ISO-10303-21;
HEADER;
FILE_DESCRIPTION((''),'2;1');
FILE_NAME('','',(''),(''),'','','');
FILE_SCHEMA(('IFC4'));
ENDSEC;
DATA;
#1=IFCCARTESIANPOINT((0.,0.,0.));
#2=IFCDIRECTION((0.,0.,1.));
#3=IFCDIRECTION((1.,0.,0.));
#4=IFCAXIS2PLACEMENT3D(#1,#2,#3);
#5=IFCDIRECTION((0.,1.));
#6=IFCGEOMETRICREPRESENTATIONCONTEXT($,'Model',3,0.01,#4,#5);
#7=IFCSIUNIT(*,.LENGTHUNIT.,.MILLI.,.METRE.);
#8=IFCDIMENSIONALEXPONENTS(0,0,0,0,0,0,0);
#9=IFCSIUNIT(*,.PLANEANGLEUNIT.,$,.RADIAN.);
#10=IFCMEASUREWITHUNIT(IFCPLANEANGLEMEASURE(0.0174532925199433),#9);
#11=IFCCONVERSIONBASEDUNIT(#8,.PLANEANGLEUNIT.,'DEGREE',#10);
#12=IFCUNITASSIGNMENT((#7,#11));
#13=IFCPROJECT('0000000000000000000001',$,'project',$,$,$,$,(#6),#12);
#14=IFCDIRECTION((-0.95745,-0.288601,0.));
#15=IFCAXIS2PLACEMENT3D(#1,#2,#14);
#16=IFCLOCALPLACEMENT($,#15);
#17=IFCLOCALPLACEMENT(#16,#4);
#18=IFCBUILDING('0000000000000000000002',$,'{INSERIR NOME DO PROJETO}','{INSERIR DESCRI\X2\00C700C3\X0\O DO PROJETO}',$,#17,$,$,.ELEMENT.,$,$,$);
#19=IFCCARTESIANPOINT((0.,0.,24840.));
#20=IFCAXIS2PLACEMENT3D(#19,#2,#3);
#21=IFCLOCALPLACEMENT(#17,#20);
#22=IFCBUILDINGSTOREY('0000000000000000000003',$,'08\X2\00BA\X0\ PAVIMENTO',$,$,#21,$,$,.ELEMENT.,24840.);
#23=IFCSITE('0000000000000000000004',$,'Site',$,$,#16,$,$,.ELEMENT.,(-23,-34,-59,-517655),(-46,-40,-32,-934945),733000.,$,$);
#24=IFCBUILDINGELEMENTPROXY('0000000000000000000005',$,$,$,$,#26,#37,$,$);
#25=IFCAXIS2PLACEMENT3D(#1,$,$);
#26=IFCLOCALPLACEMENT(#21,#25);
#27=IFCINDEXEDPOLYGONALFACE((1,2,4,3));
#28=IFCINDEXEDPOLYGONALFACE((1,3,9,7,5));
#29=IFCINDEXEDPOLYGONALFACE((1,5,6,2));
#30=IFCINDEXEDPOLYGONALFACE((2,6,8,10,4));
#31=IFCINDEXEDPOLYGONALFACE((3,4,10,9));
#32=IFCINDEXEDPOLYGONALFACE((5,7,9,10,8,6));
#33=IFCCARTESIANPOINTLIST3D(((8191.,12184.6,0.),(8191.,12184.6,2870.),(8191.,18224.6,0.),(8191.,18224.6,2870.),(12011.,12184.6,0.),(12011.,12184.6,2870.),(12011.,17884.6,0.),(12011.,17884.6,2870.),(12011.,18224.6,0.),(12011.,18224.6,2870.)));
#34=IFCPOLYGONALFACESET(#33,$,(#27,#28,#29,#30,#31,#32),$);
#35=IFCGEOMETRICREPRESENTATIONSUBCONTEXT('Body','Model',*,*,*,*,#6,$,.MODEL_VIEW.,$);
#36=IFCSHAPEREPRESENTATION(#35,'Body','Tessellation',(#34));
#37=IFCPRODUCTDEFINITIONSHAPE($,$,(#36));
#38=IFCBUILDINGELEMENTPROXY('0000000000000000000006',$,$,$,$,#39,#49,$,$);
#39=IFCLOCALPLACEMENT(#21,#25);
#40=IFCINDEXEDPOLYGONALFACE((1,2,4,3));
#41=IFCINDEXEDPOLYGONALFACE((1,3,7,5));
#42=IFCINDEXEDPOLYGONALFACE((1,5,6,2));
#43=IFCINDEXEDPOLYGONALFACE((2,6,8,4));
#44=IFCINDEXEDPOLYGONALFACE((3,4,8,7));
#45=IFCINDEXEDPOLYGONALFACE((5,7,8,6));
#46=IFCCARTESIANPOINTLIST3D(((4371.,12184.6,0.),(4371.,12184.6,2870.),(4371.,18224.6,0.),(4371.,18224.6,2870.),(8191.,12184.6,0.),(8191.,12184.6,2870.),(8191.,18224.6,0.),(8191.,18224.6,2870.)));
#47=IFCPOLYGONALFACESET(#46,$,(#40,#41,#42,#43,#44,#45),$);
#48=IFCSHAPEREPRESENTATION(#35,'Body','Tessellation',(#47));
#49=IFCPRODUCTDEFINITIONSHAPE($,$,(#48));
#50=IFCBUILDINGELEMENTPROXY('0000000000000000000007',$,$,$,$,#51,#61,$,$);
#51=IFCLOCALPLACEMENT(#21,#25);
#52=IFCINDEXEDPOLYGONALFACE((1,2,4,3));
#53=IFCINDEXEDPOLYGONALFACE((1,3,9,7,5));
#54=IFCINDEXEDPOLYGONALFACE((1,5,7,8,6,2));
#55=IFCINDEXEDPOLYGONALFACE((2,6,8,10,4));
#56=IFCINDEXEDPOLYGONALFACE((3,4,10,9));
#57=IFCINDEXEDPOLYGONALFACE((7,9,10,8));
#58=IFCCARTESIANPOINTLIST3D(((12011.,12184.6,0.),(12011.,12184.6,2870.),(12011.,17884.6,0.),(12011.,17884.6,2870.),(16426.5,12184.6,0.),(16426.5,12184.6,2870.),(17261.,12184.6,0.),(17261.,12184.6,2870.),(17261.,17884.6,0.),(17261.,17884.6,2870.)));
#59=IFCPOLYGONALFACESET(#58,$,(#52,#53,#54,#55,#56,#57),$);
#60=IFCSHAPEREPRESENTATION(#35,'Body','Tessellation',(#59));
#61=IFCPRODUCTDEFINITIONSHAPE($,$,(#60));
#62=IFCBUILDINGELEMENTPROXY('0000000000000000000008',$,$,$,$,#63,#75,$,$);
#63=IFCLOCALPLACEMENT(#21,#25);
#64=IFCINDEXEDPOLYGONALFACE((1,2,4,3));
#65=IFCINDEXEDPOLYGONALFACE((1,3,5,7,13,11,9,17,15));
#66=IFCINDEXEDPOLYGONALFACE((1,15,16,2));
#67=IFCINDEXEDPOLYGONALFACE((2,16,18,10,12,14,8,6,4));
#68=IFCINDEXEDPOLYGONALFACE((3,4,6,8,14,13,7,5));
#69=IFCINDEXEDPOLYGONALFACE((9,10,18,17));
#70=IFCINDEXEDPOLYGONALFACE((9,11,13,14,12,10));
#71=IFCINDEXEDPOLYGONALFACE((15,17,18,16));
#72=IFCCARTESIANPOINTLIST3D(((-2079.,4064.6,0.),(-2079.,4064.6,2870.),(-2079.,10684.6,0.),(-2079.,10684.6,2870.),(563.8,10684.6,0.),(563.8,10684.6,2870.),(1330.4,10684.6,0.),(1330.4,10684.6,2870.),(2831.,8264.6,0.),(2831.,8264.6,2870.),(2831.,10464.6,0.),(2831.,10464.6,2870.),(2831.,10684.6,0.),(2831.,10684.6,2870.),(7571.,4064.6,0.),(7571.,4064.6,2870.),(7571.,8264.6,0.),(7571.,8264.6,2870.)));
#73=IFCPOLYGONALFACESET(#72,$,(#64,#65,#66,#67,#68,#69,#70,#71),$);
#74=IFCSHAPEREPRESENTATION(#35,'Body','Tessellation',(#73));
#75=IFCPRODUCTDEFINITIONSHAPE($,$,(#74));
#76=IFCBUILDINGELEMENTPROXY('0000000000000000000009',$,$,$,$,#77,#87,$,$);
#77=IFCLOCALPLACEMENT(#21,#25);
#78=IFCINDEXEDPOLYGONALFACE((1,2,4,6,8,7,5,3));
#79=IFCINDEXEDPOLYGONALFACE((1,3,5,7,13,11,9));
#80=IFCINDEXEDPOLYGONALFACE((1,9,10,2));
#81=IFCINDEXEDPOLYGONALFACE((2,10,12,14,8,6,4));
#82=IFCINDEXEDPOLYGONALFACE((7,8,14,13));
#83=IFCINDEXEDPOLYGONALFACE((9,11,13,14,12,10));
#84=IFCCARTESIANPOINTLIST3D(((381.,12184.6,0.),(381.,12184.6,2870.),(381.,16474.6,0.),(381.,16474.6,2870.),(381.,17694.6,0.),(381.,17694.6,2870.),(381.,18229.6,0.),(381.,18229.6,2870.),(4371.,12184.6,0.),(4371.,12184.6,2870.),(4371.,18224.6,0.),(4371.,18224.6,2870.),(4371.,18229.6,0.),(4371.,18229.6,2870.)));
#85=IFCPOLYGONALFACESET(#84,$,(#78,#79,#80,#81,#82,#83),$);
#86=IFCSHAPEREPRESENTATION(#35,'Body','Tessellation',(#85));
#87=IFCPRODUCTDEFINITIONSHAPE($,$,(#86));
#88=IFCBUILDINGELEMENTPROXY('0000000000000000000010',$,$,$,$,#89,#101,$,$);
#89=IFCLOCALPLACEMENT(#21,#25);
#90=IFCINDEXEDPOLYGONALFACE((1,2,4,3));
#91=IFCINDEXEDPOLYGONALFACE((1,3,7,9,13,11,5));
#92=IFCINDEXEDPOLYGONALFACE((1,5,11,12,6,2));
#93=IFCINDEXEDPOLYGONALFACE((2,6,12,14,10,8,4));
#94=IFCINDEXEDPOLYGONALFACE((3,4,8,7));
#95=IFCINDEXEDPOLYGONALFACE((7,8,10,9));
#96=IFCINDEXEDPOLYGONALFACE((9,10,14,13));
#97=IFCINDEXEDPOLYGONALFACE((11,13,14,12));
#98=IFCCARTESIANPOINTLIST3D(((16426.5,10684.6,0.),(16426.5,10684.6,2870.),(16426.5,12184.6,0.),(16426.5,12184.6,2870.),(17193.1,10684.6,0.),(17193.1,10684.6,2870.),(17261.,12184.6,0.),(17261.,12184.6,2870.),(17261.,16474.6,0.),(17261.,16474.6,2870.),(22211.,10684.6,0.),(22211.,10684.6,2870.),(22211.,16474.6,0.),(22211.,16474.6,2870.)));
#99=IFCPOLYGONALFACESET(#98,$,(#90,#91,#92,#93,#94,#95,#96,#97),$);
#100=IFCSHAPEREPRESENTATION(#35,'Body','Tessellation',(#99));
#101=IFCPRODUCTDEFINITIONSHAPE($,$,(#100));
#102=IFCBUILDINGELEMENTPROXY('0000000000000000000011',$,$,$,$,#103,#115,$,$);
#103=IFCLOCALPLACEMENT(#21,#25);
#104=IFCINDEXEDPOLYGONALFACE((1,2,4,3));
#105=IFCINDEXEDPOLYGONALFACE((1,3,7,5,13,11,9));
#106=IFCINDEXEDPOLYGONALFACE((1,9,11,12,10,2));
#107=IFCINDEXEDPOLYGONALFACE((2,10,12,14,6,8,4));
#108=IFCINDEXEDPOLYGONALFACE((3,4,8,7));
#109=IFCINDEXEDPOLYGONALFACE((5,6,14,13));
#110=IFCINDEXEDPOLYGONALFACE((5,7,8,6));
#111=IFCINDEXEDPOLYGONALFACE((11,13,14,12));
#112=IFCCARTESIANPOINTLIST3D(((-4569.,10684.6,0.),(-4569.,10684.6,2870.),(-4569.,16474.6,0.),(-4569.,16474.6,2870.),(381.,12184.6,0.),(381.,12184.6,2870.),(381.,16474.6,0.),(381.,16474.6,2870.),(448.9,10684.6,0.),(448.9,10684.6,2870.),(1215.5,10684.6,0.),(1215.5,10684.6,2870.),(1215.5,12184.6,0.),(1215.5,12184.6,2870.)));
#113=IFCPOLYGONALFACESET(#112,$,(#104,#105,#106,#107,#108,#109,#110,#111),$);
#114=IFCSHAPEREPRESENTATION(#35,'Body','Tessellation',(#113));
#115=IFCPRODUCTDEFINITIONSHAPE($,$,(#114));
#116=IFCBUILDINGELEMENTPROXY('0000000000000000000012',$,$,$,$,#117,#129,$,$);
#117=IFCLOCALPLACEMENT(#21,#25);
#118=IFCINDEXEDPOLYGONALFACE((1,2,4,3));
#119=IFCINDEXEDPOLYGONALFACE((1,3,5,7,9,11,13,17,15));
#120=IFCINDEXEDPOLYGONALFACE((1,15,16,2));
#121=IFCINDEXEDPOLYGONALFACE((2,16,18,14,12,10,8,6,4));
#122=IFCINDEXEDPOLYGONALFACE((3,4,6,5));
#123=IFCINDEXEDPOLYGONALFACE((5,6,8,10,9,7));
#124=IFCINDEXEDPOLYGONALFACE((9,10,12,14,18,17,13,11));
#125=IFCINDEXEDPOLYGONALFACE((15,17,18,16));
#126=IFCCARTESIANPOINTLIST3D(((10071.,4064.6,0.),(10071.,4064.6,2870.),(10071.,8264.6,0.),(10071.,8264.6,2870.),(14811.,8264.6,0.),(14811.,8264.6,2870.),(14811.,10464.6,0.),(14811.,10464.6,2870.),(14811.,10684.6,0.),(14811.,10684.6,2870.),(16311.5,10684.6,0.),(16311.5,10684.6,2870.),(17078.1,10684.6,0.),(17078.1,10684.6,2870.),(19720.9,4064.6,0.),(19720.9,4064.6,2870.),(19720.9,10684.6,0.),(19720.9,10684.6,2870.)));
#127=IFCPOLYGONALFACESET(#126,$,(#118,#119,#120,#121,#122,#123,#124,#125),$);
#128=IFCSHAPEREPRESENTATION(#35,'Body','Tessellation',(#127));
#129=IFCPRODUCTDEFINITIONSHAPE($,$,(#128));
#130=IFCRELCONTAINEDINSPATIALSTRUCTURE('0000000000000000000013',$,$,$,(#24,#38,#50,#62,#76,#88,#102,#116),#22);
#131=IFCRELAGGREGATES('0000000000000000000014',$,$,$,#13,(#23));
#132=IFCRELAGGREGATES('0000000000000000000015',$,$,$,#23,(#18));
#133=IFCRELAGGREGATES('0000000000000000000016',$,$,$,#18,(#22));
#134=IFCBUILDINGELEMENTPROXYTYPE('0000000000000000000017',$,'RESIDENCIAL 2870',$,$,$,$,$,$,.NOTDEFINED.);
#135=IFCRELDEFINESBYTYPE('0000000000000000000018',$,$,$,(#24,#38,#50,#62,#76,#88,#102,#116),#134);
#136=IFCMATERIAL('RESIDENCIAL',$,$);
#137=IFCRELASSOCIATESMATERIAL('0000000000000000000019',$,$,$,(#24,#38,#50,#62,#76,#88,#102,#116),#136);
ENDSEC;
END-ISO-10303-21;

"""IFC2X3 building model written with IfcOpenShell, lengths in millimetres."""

from ifc_helpers import new_model, entity, si_unit, converted_unit, direction, frame, origin_with_axes, place, context, subcontext, project, spatial, polyline, outline, extrude, material, type_object, element, save


model = new_model("IFC2X3")

# Units and contexts
model_context = context("Model", 3, precision=0.01, world=origin_with_axes(), true_north=direction((0.0, 1.0)))
body_context = subcontext(model_context, "Body", "Model", "MODEL_VIEW")
ifc_project = project(units=[si_unit("LENGTHUNIT", "METRE", prefix="MILLI"), converted_unit("PLANEANGLEUNIT", "DEGREE", entity("IfcPlaneAngleMeasure", 0.0174532925199433), si_unit("PLANEANGLEUNIT", "RADIAN"), dimensions=[0, 0, 0, 0, 0, 0, 0])], contexts=[model_context])

# Site, building, storey
site_placement = place(None, frame((0.0, 0.0, 0.0), z_axis=(0.0, 0.0, 1.0), x_axis=(-0.95745, -0.288601, 0.0)))
site = spatial("IfcSite", under=ifc_project, at=site_placement, Name="Site", CompositionType="ELEMENT", RefLatitude=(-23, -34, -59, -517655), RefLongitude=(-46, -40, -32, -934945), RefElevation=733000.0)
building_placement = place(site_placement, origin_with_axes())
building = spatial("IfcBuilding", under=site, at=building_placement, Name="{INSERIR NOME DO PROJETO}", Description="{INSERIR DESCRIÇÃO DO PROJETO}", CompositionType="ELEMENT")
storey_placement = place(building_placement, frame((0.0, 0.0, 24840.0), z_axis=(0.0, 0.0, 1.0), x_axis=(1.0, 0.0, 0.0)))
storey = spatial("IfcBuildingStorey", under=building, at=storey_placement, Name="08º PAVIMENTO", CompositionType="ELEMENT", Elevation=24840.0)

# Building element proxies
ifc_material_1 = material(Name="RESIDENCIAL")
building_element_proxy_type_1 = type_object("IfcBuildingElementProxyType", Name="RESIDENCIAL 2870", PredefinedType="NOTDEFINED")
proxy_1_placement = place(storey_placement, frame((8191.0, 18224.6, 0.0), z_axis=(0.0, 0.0, 1.0), x_axis=(1.0, 0.0, 0.0)))
element("IfcBuildingElementProxy", 1, at=proxy_1_placement, inside=storey, type_object=building_element_proxy_type_1, material=ifc_material_1, context=body_context, shape_type="SweptSolid", body=[
    extrude(outline(polyline([(0.0, 0.0), (0.0, -6040.0), (3820.0, -6040.0), (3820.0, -340.0), (3820.0, 0.0), (0.0, 0.0)])), origin_with_axes(), (0.0, 0.0, 1.0), 2870.0),
])
proxy_2_placement = place(storey_placement, frame((4371.0, 18224.6, 0.0), z_axis=(0.0, 0.0, 1.0), x_axis=(1.0, 0.0, 0.0)))
element("IfcBuildingElementProxy", 2, at=proxy_2_placement, inside=storey, type_object=building_element_proxy_type_1, material=ifc_material_1, context=body_context, shape_type="SweptSolid", body=[
    extrude(outline(polyline([(0.0, 0.0), (0.0, -6040.0), (3820.0, -6040.0), (3820.0, 0.0), (0.0, 0.0)])), origin_with_axes(), (0.0, 0.0, 1.0), 2870.0),
])
proxy_3_placement = place(storey_placement, frame((12011.0, 12184.6, 0.0), z_axis=(0.0, 0.0, 1.0), x_axis=(1.0, 0.0, 0.0)))
element("IfcBuildingElementProxy", 3, at=proxy_3_placement, inside=storey, type_object=building_element_proxy_type_1, material=ifc_material_1, context=body_context, shape_type="SweptSolid", body=[
    extrude(outline(polyline([(0.0, 0.0), (4415.5, 0.0), (5250.0, 0.0), (5250.0, 5700.0), (0.0, 5700.0), (0.0, 0.0)])), origin_with_axes(), (0.0, 0.0, 1.0), 2870.0),
])
proxy_4_placement = place(storey_placement, frame((-2079.0, 4064.6, 0.0), z_axis=(0.0, 0.0, 1.0), x_axis=(1.0, 0.0, 0.0)))
element("IfcBuildingElementProxy", 4, at=proxy_4_placement, inside=storey, type_object=building_element_proxy_type_1, material=ifc_material_1, context=body_context, shape_type="SweptSolid", body=[
    extrude(outline(polyline([(0.0, 0.0), (9650.0, 0.0), (9650.0, 4200.0), (4910.0, 4200.0), (4910.0, 6400.0), (4910.0, 6620.0), (3409.4, 6620.0), (2642.8, 6620.0), (0.0, 6620.0), (0.0, 0.0)])), origin_with_axes(), (0.0, 0.0, 1.0), 2870.0),
])
proxy_5_placement = place(storey_placement, frame((381.0, 16474.6, 0.0), z_axis=(0.0, 0.0, 1.0), x_axis=(1.0, 0.0, 0.0)))
element("IfcBuildingElementProxy", 5, at=proxy_5_placement, inside=storey, type_object=building_element_proxy_type_1, material=ifc_material_1, context=body_context, shape_type="SweptSolid", body=[
    extrude(outline(polyline([(0.0, 0.0), (0.0, -4290.0), (3990.0, -4290.0), (3990.0, 1750.0), (3990.0, 1755.0), (0.0, 1755.0), (0.0, 1220.0), (0.0, 0.0)])), origin_with_axes(), (0.0, 0.0, 1.0), 2870.0),
])
proxy_6_placement = place(storey_placement, frame((17261.0, 12184.6, 0.0), z_axis=(0.0, 0.0, 1.0), x_axis=(1.0, 0.0, 0.0)))
element("IfcBuildingElementProxy", 6, at=proxy_6_placement, inside=storey, type_object=building_element_proxy_type_1, material=ifc_material_1, context=body_context, shape_type="SweptSolid", body=[
    extrude(outline(polyline([(0.0, 0.0), (-834.5, 0.0), (-834.5, -1500.0), (-67.9, -1500.0), (4950.0, -1500.0), (4950.0, 4290.0), (0.0, 4290.0), (0.0, 0.0)])), origin_with_axes(), (0.0, 0.0, 1.0), 2870.0),
])
proxy_7_placement = place(storey_placement, frame((-4569.0, 16474.6, 0.0), z_axis=(0.0, 0.0, 1.0), x_axis=(1.0, 0.0, 0.0)))
element("IfcBuildingElementProxy", 7, at=proxy_7_placement, inside=storey, type_object=building_element_proxy_type_1, material=ifc_material_1, context=body_context, shape_type="SweptSolid", body=[
    extrude(outline(polyline([(0.0, 0.0), (0.0, -5790.0), (5017.9, -5790.0), (5784.5, -5790.0), (5784.5, -4290.0), (4950.0, -4290.0), (4950.0, 0.0), (0.0, 0.0)])), origin_with_axes(), (0.0, 0.0, 1.0), 2870.0),
])
proxy_8_placement = place(storey_placement, frame((19720.9, 4064.6, 0.0), z_axis=(0.0, 0.0, 1.0), x_axis=(1.0, 0.0, 0.0)))
element("IfcBuildingElementProxy", 8, at=proxy_8_placement, inside=storey, type_object=building_element_proxy_type_1, material=ifc_material_1, context=body_context, shape_type="SweptSolid", body=[
    extrude(outline(polyline([(0.0, 0.0), (0.0, 6620.0), (-2642.8, 6620.0), (-3409.4, 6620.0), (-4910.0, 6620.0), (-4910.0, 6400.0), (-4910.0, 4200.0), (-9650.0, 4200.0), (-9650.0, 0.0), (0.0, 0.0)])), origin_with_axes(), (0.0, 0.0, 1.0), 2870.0),
])

save(model, "model.ifc")
